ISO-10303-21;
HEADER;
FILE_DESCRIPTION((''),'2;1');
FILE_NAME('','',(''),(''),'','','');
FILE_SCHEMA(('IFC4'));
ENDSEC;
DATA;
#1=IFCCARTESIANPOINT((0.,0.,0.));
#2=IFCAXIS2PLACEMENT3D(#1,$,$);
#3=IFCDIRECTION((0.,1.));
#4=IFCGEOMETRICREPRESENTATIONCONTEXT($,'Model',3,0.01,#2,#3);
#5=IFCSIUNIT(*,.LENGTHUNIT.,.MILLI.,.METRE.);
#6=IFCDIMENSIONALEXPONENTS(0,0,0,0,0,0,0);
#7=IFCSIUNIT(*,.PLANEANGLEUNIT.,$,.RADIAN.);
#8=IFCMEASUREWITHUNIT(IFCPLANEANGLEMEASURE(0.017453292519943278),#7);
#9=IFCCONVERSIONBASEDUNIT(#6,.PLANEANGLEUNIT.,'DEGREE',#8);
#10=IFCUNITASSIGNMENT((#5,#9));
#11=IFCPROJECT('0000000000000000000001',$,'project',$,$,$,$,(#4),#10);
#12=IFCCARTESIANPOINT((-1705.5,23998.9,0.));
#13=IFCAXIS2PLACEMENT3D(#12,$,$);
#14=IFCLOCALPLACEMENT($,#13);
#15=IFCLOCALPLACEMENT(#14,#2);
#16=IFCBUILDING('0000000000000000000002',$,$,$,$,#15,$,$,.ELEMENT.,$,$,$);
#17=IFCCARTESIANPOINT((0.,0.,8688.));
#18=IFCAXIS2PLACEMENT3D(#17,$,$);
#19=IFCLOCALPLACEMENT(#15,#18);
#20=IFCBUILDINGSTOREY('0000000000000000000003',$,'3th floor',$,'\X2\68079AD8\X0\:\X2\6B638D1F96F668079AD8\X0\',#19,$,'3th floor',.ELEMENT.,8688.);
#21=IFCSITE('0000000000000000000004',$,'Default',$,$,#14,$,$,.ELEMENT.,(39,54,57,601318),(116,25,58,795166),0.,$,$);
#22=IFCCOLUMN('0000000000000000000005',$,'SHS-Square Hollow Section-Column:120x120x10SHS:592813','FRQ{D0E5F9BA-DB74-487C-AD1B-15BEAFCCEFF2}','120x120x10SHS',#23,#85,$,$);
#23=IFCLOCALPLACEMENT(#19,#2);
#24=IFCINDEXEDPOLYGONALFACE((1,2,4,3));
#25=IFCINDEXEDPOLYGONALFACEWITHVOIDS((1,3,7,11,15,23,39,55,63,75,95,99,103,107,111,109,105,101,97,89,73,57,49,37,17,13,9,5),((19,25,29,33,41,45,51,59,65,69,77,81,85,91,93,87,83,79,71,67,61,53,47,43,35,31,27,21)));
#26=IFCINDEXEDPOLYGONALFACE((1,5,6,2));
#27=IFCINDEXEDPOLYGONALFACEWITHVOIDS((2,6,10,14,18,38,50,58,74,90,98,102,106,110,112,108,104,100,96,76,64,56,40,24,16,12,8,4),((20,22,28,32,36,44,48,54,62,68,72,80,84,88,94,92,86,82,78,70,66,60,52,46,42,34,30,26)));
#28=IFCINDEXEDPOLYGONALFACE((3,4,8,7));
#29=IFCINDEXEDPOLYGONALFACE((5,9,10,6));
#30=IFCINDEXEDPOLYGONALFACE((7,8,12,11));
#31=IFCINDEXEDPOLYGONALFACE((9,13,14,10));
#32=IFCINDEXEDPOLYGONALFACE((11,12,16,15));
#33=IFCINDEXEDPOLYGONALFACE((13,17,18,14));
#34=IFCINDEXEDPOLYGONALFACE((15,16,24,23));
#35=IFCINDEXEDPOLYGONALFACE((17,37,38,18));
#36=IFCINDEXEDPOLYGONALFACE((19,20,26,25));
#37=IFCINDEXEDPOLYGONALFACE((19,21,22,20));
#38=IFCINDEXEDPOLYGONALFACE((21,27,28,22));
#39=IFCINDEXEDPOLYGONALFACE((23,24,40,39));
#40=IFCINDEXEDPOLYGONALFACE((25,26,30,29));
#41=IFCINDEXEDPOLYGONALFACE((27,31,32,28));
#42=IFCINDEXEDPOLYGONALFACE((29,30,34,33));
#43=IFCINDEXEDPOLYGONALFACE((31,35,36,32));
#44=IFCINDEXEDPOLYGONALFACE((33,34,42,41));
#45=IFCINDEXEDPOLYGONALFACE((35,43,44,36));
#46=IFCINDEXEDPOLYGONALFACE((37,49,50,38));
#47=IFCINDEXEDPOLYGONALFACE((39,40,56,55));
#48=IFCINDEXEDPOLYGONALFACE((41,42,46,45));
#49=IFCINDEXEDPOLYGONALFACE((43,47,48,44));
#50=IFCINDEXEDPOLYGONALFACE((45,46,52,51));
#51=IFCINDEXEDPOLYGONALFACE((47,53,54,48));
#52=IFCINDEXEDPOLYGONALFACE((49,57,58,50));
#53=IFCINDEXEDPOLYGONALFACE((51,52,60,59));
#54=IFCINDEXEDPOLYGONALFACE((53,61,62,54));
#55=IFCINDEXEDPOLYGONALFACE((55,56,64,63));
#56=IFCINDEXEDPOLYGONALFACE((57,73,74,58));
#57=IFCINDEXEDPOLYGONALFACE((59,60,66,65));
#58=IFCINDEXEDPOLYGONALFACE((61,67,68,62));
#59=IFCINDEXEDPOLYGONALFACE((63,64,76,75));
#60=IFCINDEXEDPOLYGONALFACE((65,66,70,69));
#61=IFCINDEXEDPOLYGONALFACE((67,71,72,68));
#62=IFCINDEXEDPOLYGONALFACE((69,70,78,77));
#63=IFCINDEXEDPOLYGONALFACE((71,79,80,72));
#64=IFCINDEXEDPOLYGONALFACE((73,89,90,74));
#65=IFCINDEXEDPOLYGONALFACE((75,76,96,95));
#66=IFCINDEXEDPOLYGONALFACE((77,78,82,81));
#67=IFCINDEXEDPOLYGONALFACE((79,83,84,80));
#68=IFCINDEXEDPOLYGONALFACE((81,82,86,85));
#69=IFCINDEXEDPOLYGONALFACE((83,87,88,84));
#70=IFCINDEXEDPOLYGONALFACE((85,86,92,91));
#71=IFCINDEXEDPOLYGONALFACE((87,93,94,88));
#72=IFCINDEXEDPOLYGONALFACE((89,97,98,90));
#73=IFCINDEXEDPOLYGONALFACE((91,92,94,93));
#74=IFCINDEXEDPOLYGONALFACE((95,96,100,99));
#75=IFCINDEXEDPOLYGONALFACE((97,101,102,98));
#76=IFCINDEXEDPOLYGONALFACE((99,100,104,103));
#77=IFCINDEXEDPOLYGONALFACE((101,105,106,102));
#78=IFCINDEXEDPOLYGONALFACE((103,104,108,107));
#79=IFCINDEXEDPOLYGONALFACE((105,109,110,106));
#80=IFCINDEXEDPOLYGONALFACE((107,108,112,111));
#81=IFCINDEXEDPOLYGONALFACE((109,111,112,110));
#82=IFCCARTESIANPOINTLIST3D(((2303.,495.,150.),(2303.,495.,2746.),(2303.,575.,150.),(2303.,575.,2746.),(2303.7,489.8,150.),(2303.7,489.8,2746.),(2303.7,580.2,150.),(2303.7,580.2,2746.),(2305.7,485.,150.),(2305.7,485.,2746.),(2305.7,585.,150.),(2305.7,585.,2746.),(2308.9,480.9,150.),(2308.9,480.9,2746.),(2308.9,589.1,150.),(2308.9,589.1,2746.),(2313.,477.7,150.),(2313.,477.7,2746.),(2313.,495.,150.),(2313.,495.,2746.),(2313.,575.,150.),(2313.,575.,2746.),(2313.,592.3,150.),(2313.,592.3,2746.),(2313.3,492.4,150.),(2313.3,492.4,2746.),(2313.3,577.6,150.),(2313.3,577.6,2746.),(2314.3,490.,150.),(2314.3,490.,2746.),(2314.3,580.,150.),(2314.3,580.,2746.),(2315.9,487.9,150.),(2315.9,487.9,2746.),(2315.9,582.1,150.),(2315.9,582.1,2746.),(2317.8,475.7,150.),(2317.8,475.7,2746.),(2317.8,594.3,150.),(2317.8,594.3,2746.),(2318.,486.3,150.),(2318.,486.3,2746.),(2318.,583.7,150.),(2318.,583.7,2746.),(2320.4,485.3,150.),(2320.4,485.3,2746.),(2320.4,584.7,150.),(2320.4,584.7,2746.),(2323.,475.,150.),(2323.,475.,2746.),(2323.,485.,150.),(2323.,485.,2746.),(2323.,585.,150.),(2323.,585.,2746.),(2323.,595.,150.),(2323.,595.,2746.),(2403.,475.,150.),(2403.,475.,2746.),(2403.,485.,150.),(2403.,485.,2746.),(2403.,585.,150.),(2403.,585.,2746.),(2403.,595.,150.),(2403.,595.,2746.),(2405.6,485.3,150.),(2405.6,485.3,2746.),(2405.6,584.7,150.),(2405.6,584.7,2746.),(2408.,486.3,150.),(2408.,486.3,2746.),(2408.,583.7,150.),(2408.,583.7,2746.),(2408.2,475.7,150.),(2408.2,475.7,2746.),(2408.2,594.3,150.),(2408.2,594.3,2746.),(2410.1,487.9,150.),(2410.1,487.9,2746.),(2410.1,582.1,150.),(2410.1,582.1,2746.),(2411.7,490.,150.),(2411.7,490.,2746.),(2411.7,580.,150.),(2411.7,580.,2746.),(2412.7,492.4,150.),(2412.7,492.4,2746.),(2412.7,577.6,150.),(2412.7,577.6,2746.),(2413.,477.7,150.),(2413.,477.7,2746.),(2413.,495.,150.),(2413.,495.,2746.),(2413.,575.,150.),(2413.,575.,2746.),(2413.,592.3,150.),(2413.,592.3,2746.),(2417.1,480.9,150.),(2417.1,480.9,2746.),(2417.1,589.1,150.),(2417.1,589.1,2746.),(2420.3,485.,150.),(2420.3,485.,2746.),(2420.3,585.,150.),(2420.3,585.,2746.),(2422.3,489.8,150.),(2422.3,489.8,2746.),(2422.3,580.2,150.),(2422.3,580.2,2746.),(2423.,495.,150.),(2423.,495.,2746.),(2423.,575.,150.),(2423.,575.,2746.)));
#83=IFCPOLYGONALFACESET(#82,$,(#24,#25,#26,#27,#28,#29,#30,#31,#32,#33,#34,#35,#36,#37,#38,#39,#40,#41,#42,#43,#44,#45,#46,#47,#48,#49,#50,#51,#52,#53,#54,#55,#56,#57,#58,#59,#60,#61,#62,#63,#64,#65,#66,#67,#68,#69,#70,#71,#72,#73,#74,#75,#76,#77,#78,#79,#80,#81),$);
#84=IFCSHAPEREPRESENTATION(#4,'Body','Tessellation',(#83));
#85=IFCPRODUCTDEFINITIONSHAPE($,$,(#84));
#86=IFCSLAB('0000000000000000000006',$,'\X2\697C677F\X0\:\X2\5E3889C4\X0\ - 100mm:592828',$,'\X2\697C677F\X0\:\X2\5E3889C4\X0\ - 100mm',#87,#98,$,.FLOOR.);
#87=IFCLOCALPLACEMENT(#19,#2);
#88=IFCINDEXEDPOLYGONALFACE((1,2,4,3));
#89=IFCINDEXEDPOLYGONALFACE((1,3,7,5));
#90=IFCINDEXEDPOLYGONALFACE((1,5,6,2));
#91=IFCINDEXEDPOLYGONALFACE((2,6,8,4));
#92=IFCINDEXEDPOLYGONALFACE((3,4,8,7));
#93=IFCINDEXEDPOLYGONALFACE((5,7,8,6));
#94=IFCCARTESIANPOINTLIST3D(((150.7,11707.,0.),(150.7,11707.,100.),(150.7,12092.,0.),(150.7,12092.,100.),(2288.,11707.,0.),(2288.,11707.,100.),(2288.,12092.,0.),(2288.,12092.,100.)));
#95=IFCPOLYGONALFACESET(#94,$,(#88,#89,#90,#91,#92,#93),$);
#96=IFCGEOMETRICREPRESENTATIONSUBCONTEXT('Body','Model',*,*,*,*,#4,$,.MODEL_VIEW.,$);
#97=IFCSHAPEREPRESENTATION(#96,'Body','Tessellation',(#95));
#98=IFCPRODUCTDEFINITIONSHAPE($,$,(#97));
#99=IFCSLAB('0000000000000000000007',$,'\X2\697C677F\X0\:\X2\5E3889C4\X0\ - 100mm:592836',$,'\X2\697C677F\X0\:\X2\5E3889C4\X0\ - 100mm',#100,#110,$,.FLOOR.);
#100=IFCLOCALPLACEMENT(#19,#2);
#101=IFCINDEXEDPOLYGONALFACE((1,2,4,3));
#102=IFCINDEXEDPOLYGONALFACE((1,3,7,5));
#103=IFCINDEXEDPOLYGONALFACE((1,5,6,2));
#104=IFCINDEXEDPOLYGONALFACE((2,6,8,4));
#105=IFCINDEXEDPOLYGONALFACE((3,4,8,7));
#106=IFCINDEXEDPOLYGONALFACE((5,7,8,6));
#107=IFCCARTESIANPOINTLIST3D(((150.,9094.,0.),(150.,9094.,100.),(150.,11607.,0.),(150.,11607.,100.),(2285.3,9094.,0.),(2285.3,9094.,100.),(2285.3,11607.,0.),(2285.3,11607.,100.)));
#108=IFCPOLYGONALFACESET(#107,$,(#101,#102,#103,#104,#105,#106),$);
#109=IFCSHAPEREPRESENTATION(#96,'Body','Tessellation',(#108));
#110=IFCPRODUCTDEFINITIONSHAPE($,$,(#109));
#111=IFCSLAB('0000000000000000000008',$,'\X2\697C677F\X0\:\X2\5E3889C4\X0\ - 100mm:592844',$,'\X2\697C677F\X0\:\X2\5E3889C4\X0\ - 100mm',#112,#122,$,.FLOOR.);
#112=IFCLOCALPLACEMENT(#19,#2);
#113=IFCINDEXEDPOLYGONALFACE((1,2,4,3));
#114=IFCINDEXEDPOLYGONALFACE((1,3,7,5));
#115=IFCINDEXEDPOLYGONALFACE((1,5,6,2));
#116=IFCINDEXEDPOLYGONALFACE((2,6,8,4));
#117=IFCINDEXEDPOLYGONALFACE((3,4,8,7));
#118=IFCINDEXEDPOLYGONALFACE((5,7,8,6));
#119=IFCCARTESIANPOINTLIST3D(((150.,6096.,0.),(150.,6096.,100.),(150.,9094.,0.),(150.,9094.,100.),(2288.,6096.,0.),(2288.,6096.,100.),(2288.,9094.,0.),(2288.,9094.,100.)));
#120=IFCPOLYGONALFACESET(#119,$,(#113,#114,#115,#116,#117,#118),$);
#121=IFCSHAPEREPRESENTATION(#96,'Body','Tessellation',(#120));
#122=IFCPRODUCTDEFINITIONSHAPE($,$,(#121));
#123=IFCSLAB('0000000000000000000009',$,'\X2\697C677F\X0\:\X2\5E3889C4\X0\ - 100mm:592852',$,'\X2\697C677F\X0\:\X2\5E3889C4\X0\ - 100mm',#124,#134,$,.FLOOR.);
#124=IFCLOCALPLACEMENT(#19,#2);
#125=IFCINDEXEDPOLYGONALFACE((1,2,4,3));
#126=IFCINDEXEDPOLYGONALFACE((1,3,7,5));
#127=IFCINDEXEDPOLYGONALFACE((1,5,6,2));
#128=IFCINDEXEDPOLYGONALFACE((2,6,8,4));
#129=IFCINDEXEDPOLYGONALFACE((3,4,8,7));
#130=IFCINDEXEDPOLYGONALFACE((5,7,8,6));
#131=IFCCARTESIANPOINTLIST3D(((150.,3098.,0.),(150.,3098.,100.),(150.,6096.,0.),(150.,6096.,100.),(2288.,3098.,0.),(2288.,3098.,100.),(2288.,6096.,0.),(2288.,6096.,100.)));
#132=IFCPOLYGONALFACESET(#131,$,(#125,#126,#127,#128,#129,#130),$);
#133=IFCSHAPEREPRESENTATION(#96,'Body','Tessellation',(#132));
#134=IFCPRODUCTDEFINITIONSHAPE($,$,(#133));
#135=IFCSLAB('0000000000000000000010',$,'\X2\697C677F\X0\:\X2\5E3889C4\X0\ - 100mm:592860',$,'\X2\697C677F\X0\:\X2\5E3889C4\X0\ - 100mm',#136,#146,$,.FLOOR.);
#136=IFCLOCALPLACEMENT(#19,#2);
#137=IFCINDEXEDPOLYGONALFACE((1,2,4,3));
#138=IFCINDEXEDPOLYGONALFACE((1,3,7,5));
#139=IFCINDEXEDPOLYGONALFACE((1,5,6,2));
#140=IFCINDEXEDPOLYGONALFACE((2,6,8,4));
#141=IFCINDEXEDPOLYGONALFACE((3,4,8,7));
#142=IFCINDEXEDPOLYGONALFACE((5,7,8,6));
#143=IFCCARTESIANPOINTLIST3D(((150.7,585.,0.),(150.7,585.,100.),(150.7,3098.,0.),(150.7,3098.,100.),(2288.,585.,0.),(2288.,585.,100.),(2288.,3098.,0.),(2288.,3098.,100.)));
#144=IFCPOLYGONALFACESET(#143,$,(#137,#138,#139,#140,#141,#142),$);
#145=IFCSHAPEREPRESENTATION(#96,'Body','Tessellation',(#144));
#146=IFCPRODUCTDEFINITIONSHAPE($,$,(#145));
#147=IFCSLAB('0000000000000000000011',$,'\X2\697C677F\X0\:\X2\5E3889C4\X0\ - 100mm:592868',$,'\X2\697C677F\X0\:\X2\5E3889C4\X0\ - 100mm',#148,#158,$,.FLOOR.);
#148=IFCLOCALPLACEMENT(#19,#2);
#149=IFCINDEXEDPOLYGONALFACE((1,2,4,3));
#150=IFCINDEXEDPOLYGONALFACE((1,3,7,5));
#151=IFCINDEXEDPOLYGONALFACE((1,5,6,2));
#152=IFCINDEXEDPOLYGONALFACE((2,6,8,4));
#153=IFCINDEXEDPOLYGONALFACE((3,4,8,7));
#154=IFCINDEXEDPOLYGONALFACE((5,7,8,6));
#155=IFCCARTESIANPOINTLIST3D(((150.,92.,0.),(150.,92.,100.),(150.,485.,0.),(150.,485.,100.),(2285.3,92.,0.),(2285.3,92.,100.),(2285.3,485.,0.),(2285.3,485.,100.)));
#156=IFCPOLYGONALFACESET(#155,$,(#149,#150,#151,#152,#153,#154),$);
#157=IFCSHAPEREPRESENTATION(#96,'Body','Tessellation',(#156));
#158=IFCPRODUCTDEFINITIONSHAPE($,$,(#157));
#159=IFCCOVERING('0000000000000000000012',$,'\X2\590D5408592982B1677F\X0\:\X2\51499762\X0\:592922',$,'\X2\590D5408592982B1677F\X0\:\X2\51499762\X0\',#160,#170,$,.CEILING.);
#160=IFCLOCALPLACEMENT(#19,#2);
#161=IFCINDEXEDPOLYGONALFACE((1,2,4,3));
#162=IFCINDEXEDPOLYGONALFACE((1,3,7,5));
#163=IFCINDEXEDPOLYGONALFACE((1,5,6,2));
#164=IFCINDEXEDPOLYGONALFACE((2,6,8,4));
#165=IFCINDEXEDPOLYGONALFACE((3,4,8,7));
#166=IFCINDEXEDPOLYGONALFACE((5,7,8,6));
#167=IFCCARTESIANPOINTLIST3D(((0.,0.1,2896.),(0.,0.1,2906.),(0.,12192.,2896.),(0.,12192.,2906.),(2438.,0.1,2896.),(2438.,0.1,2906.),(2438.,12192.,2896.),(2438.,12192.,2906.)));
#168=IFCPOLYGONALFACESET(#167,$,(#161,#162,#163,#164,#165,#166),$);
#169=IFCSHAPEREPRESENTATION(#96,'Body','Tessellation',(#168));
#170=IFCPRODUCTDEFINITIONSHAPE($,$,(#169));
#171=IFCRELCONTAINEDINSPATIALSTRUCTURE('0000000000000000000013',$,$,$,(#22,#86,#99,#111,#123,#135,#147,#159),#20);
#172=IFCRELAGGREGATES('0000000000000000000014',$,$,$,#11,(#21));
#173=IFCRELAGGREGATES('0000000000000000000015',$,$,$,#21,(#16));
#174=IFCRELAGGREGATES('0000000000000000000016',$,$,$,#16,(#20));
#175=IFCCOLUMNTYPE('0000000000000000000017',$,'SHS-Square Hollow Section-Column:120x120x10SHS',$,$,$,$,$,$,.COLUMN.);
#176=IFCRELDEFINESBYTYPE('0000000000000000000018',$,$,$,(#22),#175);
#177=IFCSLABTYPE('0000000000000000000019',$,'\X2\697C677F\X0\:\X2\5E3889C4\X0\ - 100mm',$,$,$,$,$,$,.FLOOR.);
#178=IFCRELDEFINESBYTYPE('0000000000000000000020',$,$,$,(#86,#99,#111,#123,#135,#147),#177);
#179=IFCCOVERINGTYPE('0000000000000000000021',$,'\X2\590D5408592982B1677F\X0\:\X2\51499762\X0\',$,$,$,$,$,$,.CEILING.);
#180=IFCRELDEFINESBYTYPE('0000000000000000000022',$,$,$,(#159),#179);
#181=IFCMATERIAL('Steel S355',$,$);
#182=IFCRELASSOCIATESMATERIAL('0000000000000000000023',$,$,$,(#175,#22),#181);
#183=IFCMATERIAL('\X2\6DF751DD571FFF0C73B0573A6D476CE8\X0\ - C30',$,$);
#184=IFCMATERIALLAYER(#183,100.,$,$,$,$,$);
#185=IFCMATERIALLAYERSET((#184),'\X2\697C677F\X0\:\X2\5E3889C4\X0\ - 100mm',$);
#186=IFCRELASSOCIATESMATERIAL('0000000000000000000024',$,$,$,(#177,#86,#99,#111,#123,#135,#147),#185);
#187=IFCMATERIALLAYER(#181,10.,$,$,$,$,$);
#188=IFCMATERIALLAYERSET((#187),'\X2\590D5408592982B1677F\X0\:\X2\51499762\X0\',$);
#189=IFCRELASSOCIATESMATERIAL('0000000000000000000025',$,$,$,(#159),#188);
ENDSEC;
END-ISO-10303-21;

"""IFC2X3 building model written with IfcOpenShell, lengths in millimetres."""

from ifc_helpers import new_model, entity, si_unit, converted_unit, direction, frame, frame_2d, origin, origin_2d, origin_2d_with_axis, place, context, subcontext, project, spatial, rectangle, hollow_rectangle, extrude, clip, halfspace, material, layer, layer_set, layer_usage, type_object, element, save


model = new_model("IFC2X3")

# Units and contexts
model_context = context("Model", 3, precision=0.01, world=origin(), true_north=direction((0.0, 1.0)))
body_context = subcontext(model_context, "Body", "Model", "MODEL_VIEW")
ifc_project = project(units=[si_unit("LENGTHUNIT", "METRE", prefix="MILLI"), converted_unit("PLANEANGLEUNIT", "DEGREE", entity("IfcPlaneAngleMeasure", 0.017453292519943278), si_unit("PLANEANGLEUNIT", "RADIAN"), dimensions=[0, 0, 0, 0, 0, 0, 0])], contexts=[model_context])

# Site, building, storey
site_placement = place(None, frame((-1705.5, 23998.9, 0.0)))
site = spatial("IfcSite", under=ifc_project, at=site_placement, Name="Default", CompositionType="ELEMENT", RefLatitude=(39, 54, 57, 601318), RefLongitude=(116, 25, 58, 795166), RefElevation=0.0)
building_placement = place(site_placement, origin())
building = spatial("IfcBuilding", under=site, at=building_placement, CompositionType="ELEMENT")
storey_placement = place(building_placement, frame((0.0, 0.0, 8688.0)))
storey = spatial("IfcBuildingStorey", under=building, at=storey_placement, Name="3th floor", ObjectType="标高:正负零标高", LongName="3th floor", CompositionType="ELEMENT", Elevation=8688.0)

# Shared definitions
ifc_material_1 = material(Name="Steel S355")

# Column
column_type_1 = type_object("IfcColumnType", Name="SHS-Square Hollow Section-Column:120x120x10SHS", PredefinedType="COLUMN", material=ifc_material_1)
column_1_placement = place(storey_placement, frame((2363.0, 535.0, 2746.0), z_axis=(0.0, 0.0, 1.0), x_axis=(0.0, -1.0, 0.0)))
element("IfcColumn", 1, at=column_1_placement, inside=storey, type_object=column_type_1, material=ifc_material_1, Name="SHS-Square Hollow Section-Column:120x120x10SHS:592813", Description="FRQ{D0E5F9BA-DB74-487C-AD1B-15BEAFCCEFF2}", ObjectType="120x120x10SHS", context=model_context, shape_type="Clipping", body=[
    clip(extrude(hollow_rectangle(XDim=120.0, YDim=120.0, WallThickness=10.0, InnerFilletRadius=10.0, OuterFilletRadius=20.0, at=origin_2d()), origin(), (0.0, 0.0, -1.0), 2680.9), halfspace(frame((535.0, -2363.0, -2596.0), z_axis=(0.0, 0.0, 1.0), x_axis=(0.0, 1.0, 0.0)), True)),
])

# Slabs
ifc_material_2 = material(Name="混凝土，现场浇注 - C30")
ifc_layer_1 = layer(ifc_material_2, 100.0)
ifc_layer_set_1 = layer_set([ifc_layer_1], Name="楼板:常规 - 100mm")
ifc_layer_usage_1 = layer_usage(ifc_layer_set_1, "AXIS3", "POSITIVE", 0.0)
slab_type = type_object("IfcSlabType", Name="楼板:常规 - 100mm", PredefinedType="FLOOR", material=ifc_layer_set_1)
slab_1_placement = place(storey_placement, origin())
element("IfcSlab", 2, at=slab_1_placement, inside=storey, type_object=slab_type, material=ifc_layer_usage_1, Name="楼板:常规 - 100mm:592828", ObjectType="楼板:常规 - 100mm", PredefinedType="FLOOR", context=body_context, shape_type="SweptSolid", body=[
    extrude(rectangle(XDim=385.0, YDim=2137.3, at=origin_2d_with_axis()), frame((1219.3, 11899.5, 100.0), z_axis=(0.0, 0.0, -1.0), x_axis=(0.0, 1.0, 0.0)), (0.0, 0.0, 1.0), 100.0),
])
ifc_layer_usage_2 = layer_usage(ifc_layer_set_1, "AXIS3", "POSITIVE", 0.0)
slab_2_placement = place(storey_placement, origin())
element("IfcSlab", 3, at=slab_2_placement, inside=storey, type_object=slab_type, material=ifc_layer_usage_2, Name="楼板:常规 - 100mm:592836", ObjectType="楼板:常规 - 100mm", PredefinedType="FLOOR", context=body_context, shape_type="SweptSolid", body=[
    extrude(rectangle(XDim=2513.0, YDim=2135.3, at=frame_2d((0.0, 0.0), x_axis=(1.0, 0.0))), frame((1217.6, 10350.5, 100.0), z_axis=(0.0, 0.0, -1.0), x_axis=(0.0, 1.0, 0.0)), (0.0, 0.0, 1.0), 100.0),
])
ifc_layer_usage_3 = layer_usage(ifc_layer_set_1, "AXIS3", "POSITIVE", 0.0)
slab_3_placement = place(storey_placement, origin())
element("IfcSlab", 4, at=slab_3_placement, inside=storey, type_object=slab_type, material=ifc_layer_usage_3, Name="楼板:常规 - 100mm:592844", ObjectType="楼板:常规 - 100mm", PredefinedType="FLOOR", context=body_context, shape_type="SweptSolid", body=[
    extrude(rectangle(XDim=2998.0, YDim=2138.0, at=origin_2d_with_axis()), frame((1219.0, 7595.0, 100.0), z_axis=(0.0, 0.0, -1.0), x_axis=(0.0, 1.0, 0.0)), (0.0, 0.0, 1.0), 100.0),
])
ifc_layer_usage_4 = layer_usage(ifc_layer_set_1, "AXIS3", "POSITIVE", 0.0)
slab_4_placement = place(storey_placement, origin())
element("IfcSlab", 5, at=slab_4_placement, inside=storey, type_object=slab_type, material=ifc_layer_usage_4, Name="楼板:常规 - 100mm:592852", ObjectType="楼板:常规 - 100mm", PredefinedType="FLOOR", context=body_context, shape_type="SweptSolid", body=[
    extrude(rectangle(XDim=2998.0, YDim=2138.0, at=origin_2d_with_axis()), frame((1219.0, 4597.0, 100.0), z_axis=(0.0, 0.0, -1.0), x_axis=(0.0, 1.0, 0.0)), (0.0, 0.0, 1.0), 100.0),
])
ifc_layer_usage_5 = layer_usage(ifc_layer_set_1, "AXIS3", "POSITIVE", 0.0)
slab_5_placement = place(storey_placement, origin())
element("IfcSlab", 6, at=slab_5_placement, inside=storey, type_object=slab_type, material=ifc_layer_usage_5, Name="楼板:常规 - 100mm:592860", ObjectType="楼板:常规 - 100mm", PredefinedType="FLOOR", context=body_context, shape_type="SweptSolid", body=[
    extrude(rectangle(XDim=2513.0, YDim=2137.3, at=frame_2d((0.0, 0.0), x_axis=(1.0, 0.0))), frame((1219.3, 1841.5, 100.0), z_axis=(0.0, 0.0, -1.0), x_axis=(0.0, 1.0, 0.0)), (0.0, 0.0, 1.0), 100.0),
])
ifc_layer_usage_6 = layer_usage(ifc_layer_set_1, "AXIS3", "POSITIVE", 0.0)
slab_6_placement = place(storey_placement, origin())
element("IfcSlab", 7, at=slab_6_placement, inside=storey, type_object=slab_type, material=ifc_layer_usage_6, Name="楼板:常规 - 100mm:592868", ObjectType="楼板:常规 - 100mm", PredefinedType="FLOOR", context=body_context, shape_type="SweptSolid", body=[
    extrude(rectangle(XDim=393.0, YDim=2135.3, at=frame_2d((0.0, 0.0), x_axis=(1.0, 0.0))), frame((1217.7, 288.5, 100.0), z_axis=(0.0, 0.0, -1.0), x_axis=(0.0, 1.0, 0.0)), (0.0, 0.0, 1.0), 100.0),
])

# Covering
ifc_layer_2 = layer(ifc_material_1, 10.0)
ifc_layer_set_2 = layer_set([ifc_layer_2], Name="复合天花板:光面")
ifc_layer_usage_7 = layer_usage(ifc_layer_set_2, "AXIS3", "NEGATIVE", 10.0)
covering_type = type_object("IfcCoveringType", Name="复合天花板:光面", PredefinedType="CEILING")
covering_placement = place(storey_placement, origin())
element("IfcCovering", 8, at=covering_placement, inside=storey, type_object=covering_type, material=ifc_layer_usage_7, Name="复合天花板:光面:592922", ObjectType="复合天花板:光面", PredefinedType="CEILING", context=body_context, shape_type="SweptSolid", body=[
    extrude(rectangle(XDim=12191.9, YDim=2438.0, at=origin_2d_with_axis()), frame((1219.0, 6096.0, 2896.0), z_axis=(0.0, 0.0, 1.0), x_axis=(0.0, 1.0, 0.0)), (0.0, 0.0, 1.0), 10.0),
])

save(model, "model.ifc")
